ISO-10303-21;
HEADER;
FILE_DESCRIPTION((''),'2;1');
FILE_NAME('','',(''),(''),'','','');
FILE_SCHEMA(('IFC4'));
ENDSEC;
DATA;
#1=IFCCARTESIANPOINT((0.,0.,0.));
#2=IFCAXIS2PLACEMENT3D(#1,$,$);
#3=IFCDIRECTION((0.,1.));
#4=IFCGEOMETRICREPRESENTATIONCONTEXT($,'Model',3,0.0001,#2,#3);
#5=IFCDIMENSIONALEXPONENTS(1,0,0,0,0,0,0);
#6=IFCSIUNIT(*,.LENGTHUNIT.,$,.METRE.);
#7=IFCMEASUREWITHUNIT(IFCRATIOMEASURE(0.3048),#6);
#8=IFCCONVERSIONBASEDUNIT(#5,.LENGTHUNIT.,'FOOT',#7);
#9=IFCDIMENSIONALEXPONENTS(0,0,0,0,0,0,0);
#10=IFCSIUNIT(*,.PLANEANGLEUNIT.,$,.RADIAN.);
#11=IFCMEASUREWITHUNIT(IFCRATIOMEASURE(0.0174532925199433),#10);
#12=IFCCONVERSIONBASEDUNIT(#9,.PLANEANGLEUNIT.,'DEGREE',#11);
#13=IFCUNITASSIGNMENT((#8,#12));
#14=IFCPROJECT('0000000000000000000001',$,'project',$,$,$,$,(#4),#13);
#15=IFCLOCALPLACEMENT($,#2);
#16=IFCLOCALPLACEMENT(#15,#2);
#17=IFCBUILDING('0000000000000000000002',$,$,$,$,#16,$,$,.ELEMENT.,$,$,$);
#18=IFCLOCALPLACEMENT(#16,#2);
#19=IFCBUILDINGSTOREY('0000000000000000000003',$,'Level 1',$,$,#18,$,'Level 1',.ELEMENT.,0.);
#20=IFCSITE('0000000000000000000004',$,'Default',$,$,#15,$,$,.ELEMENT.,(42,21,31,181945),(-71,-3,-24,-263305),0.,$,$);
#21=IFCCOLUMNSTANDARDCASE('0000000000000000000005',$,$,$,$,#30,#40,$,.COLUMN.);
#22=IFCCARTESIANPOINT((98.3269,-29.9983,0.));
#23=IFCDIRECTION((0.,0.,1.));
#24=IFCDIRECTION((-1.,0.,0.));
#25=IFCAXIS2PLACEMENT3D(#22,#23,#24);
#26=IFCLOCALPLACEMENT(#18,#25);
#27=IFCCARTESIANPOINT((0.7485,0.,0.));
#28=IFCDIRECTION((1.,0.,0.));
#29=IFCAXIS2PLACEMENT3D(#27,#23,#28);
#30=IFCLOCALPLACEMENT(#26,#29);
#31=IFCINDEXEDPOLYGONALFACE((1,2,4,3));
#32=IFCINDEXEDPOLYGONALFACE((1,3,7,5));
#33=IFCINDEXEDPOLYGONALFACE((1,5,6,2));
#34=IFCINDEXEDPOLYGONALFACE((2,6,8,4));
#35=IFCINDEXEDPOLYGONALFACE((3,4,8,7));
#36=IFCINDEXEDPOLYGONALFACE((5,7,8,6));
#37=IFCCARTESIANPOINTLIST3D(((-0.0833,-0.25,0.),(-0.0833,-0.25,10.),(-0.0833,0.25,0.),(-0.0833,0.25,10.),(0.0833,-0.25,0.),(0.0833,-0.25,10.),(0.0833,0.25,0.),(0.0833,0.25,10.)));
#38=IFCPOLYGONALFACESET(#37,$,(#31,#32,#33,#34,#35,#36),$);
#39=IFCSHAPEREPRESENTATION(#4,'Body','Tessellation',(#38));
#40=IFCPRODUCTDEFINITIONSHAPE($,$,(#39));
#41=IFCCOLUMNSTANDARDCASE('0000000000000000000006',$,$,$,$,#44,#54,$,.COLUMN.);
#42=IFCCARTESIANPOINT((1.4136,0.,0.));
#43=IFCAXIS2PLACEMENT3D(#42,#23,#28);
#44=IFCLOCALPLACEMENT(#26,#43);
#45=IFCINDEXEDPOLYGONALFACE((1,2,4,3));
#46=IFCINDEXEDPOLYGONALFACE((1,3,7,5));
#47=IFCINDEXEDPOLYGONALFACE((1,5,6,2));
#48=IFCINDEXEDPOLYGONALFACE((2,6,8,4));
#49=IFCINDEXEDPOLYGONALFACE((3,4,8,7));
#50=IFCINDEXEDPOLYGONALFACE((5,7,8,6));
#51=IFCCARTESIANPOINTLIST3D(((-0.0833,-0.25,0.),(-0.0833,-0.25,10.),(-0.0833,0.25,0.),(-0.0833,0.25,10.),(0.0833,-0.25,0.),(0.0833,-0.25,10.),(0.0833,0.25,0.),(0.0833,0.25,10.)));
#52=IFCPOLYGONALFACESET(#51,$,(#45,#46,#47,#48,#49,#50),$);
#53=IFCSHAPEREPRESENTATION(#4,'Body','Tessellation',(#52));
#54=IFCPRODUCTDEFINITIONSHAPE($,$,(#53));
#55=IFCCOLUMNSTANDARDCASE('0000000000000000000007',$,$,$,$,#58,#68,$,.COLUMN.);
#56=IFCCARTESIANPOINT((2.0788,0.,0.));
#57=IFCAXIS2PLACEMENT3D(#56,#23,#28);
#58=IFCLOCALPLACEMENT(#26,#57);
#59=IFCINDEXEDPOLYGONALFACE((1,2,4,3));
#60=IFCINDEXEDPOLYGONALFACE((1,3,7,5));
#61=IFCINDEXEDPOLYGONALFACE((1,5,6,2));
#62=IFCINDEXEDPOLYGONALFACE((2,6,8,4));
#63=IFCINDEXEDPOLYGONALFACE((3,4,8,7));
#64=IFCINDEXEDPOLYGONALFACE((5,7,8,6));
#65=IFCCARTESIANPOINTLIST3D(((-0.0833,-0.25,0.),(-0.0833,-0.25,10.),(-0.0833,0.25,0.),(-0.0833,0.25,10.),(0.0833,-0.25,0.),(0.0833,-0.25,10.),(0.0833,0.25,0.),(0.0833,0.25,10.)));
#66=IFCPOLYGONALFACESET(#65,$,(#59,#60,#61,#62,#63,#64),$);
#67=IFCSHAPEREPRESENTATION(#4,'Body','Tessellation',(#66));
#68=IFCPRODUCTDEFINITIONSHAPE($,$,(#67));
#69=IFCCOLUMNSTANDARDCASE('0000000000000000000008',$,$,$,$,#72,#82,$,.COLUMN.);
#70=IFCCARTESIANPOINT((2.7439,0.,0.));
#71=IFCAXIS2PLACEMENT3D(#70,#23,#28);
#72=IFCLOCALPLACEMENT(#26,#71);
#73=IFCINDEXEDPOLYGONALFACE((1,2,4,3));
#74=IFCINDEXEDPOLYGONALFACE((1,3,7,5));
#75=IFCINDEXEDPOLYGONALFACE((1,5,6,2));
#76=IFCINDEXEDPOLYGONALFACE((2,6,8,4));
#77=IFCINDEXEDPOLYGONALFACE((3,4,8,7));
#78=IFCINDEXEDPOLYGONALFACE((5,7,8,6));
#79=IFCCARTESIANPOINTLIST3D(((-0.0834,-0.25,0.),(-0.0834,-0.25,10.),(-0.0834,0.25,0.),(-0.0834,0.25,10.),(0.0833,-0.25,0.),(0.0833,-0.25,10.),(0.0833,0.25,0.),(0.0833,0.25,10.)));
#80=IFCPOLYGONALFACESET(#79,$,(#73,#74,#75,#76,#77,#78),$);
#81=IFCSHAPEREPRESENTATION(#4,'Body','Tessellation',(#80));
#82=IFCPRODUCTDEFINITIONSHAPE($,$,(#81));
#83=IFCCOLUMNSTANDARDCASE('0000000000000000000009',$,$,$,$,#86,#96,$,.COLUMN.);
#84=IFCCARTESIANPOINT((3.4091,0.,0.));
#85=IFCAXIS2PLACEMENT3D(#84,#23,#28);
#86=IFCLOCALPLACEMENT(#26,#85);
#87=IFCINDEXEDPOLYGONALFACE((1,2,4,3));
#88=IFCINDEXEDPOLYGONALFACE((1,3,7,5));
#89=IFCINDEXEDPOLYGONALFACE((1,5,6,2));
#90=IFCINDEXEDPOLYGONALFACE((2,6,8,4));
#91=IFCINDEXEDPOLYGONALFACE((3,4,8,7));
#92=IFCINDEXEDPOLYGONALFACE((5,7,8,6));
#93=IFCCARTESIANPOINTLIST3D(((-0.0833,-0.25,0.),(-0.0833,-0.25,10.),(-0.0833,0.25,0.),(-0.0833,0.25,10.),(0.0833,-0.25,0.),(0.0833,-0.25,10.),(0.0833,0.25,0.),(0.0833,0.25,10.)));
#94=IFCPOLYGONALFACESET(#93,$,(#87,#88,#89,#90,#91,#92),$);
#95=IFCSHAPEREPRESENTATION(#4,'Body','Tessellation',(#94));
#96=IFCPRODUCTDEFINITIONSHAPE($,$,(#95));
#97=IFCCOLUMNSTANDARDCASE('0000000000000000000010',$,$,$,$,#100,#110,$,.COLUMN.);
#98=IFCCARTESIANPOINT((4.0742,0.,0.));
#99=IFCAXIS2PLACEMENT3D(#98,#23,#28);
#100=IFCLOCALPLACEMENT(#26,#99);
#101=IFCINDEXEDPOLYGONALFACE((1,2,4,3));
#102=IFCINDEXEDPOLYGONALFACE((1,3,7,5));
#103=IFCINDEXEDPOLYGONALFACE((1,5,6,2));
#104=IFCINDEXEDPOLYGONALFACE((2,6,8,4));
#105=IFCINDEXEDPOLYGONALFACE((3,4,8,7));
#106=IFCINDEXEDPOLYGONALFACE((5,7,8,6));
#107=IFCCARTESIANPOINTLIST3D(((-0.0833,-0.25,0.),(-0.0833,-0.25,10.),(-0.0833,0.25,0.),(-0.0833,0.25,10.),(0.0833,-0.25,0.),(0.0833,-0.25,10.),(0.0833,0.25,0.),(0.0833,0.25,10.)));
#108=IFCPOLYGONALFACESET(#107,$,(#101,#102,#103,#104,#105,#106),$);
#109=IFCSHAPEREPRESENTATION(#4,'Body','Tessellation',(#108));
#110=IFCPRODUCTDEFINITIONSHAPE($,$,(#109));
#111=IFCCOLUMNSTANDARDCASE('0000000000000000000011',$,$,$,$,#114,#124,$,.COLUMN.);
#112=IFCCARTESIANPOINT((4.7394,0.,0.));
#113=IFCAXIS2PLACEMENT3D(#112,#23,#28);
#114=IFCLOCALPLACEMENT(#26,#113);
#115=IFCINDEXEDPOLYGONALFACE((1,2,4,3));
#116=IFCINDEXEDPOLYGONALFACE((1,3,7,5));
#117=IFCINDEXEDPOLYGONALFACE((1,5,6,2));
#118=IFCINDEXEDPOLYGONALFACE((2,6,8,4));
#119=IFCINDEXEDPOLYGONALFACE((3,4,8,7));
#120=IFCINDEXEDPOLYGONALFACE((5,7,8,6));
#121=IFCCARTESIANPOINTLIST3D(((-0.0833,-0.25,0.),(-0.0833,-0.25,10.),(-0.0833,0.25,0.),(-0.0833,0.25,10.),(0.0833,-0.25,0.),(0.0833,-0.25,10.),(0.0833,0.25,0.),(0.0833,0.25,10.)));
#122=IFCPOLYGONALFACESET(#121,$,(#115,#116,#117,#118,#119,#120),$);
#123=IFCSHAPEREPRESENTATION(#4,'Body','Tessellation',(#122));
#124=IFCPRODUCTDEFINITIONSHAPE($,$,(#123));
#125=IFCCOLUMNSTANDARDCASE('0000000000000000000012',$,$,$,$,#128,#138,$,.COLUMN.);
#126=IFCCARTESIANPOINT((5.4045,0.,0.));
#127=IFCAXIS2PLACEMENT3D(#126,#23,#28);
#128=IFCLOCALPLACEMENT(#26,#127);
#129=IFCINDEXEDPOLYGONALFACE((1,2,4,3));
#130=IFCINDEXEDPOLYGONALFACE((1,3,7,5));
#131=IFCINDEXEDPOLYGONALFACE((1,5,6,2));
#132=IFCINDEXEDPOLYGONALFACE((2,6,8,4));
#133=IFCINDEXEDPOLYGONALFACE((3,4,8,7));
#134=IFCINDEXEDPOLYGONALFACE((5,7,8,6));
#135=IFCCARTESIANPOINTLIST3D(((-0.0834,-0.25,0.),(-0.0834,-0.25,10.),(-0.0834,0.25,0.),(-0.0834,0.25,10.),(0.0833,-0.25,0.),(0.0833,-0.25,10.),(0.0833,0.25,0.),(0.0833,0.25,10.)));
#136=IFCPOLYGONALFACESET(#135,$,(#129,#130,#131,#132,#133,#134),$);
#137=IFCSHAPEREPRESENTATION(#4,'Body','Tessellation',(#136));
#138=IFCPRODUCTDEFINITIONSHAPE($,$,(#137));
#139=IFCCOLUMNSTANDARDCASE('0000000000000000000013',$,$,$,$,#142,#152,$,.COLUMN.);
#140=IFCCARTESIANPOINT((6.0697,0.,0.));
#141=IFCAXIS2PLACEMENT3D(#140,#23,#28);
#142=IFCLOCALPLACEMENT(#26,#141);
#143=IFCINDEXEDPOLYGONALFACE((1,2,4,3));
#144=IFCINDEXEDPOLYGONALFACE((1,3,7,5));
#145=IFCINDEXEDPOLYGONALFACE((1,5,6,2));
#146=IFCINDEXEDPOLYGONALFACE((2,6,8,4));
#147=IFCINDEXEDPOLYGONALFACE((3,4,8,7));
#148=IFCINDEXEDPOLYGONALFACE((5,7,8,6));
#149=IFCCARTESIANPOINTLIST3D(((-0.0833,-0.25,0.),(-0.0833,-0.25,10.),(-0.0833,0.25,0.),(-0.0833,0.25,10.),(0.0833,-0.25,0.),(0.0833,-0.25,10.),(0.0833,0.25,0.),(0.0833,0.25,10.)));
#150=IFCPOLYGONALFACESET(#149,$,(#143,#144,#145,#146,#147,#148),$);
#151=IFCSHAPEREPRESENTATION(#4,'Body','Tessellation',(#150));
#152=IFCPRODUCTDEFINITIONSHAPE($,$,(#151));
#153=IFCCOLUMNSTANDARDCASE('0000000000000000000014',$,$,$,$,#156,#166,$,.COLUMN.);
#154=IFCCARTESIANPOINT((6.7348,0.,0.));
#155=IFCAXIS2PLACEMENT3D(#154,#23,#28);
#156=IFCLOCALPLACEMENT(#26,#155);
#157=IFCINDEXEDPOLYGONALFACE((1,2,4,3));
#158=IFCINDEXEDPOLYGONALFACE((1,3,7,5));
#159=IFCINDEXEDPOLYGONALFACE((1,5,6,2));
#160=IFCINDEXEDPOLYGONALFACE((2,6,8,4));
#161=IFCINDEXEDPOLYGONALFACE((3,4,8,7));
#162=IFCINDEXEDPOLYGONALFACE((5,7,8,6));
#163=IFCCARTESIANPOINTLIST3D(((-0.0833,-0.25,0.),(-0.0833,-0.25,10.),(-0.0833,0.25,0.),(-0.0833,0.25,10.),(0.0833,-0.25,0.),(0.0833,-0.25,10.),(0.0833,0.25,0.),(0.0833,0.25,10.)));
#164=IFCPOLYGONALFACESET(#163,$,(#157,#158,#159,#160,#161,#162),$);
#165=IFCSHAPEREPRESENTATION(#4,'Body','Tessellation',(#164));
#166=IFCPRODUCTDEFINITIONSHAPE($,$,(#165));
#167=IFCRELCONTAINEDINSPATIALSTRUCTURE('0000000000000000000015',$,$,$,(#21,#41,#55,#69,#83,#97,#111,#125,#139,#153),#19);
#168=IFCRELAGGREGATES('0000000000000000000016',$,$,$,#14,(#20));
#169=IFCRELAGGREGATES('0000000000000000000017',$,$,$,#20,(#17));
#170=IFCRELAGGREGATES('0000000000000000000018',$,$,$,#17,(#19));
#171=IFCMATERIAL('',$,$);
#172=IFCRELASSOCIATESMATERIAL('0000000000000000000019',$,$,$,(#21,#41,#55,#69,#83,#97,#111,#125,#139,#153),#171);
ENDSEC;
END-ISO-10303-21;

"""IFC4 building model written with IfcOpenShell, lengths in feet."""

from ifc_helpers import new_model, entity, si_unit, converted_unit, direction, frame, origin, place, context, project, spatial, rectangle, extrude, material, element, save


model = new_model("IFC4")

# Units and contexts
model_context = context("Model", 3, precision=0.0001, world=origin(), true_north=direction((0.0, 1.0)))
ifc_project = project(units=[converted_unit("LENGTHUNIT", "FOOT", entity("IfcRatioMeasure", 0.3048), si_unit("LENGTHUNIT", "METRE"), dimensions=[1, 0, 0, 0, 0, 0, 0]), converted_unit("PLANEANGLEUNIT", "DEGREE", entity("IfcRatioMeasure", 0.0174532925199433), si_unit("PLANEANGLEUNIT", "RADIAN"), dimensions=[0, 0, 0, 0, 0, 0, 0])], contexts=[model_context])

# Site, building, storey
site_placement = place(None, origin())
site = spatial("IfcSite", under=ifc_project, at=site_placement, Name="Default", CompositionType="ELEMENT", RefLatitude=(42, 21, 31, 181945), RefLongitude=(-71, -3, -24, -263305), RefElevation=0.0)
building_placement = place(site_placement, origin())
building = spatial("IfcBuilding", under=site, at=building_placement, CompositionType="ELEMENT")
storey_placement = place(building_placement, origin())
storey = spatial("IfcBuildingStorey", under=building, at=storey_placement, Name="Level 1", LongName="Level 1", CompositionType="ELEMENT", Elevation=0.0)

# Columns
ifc_material = material(Name="")
placement = place(storey_placement, frame((98.3269, -29.9983, 0.0), z_axis=(0.0, 0.0, 1.0), x_axis=(-1.0, 0.0, 0.0)))
for number, where, z_axis, x_axis in (
    (1, (0.7485, 0.0, 0.0), (0.0, 0.0, 1.0), (1.0, 0.0, 0.0)),
    (2, (1.4136, 0.0, 0.0), (0.0, 0.0, 1.0), (1.0, 0.0, 0.0)),
    (3, (2.0788, 0.0, 0.0), (0.0, 0.0, 1.0), (1.0, 0.0, 0.0)),
    (4, (2.7439, 0.0, 0.0), (0.0, 0.0, 1.0), (1.0, 0.0, 0.0)),
    (5, (3.4091, 0.0, 0.0), (0.0, 0.0, 1.0), (1.0, 0.0, 0.0)),
    (6, (4.0742, 0.0, 0.0), (0.0, 0.0, 1.0), (1.0, 0.0, 0.0)),
    (7, (4.7394, 0.0, 0.0), (0.0, 0.0, 1.0), (1.0, 0.0, 0.0)),
    (8, (5.4045, 0.0, 0.0), (0.0, 0.0, 1.0), (1.0, 0.0, 0.0)),
    (9, (6.0697, 0.0, 0.0), (0.0, 0.0, 1.0), (1.0, 0.0, 0.0)),
    (10, (6.7348, 0.0, 0.0), (0.0, 0.0, 1.0), (1.0, 0.0, 0.0)),
):
    element("IfcColumnStandardCase", number, at=place(placement, frame(where, z_axis=z_axis, x_axis=x_axis)), inside=storey, material=ifc_material, PredefinedType="COLUMN", context=model_context, shape_type="SweptSolid", body=[
        extrude(rectangle(XDim=0.1667, YDim=0.5), origin(), (0.0, 0.0, 1.0), 10.0),
    ])

save(model, "model.ifc")
